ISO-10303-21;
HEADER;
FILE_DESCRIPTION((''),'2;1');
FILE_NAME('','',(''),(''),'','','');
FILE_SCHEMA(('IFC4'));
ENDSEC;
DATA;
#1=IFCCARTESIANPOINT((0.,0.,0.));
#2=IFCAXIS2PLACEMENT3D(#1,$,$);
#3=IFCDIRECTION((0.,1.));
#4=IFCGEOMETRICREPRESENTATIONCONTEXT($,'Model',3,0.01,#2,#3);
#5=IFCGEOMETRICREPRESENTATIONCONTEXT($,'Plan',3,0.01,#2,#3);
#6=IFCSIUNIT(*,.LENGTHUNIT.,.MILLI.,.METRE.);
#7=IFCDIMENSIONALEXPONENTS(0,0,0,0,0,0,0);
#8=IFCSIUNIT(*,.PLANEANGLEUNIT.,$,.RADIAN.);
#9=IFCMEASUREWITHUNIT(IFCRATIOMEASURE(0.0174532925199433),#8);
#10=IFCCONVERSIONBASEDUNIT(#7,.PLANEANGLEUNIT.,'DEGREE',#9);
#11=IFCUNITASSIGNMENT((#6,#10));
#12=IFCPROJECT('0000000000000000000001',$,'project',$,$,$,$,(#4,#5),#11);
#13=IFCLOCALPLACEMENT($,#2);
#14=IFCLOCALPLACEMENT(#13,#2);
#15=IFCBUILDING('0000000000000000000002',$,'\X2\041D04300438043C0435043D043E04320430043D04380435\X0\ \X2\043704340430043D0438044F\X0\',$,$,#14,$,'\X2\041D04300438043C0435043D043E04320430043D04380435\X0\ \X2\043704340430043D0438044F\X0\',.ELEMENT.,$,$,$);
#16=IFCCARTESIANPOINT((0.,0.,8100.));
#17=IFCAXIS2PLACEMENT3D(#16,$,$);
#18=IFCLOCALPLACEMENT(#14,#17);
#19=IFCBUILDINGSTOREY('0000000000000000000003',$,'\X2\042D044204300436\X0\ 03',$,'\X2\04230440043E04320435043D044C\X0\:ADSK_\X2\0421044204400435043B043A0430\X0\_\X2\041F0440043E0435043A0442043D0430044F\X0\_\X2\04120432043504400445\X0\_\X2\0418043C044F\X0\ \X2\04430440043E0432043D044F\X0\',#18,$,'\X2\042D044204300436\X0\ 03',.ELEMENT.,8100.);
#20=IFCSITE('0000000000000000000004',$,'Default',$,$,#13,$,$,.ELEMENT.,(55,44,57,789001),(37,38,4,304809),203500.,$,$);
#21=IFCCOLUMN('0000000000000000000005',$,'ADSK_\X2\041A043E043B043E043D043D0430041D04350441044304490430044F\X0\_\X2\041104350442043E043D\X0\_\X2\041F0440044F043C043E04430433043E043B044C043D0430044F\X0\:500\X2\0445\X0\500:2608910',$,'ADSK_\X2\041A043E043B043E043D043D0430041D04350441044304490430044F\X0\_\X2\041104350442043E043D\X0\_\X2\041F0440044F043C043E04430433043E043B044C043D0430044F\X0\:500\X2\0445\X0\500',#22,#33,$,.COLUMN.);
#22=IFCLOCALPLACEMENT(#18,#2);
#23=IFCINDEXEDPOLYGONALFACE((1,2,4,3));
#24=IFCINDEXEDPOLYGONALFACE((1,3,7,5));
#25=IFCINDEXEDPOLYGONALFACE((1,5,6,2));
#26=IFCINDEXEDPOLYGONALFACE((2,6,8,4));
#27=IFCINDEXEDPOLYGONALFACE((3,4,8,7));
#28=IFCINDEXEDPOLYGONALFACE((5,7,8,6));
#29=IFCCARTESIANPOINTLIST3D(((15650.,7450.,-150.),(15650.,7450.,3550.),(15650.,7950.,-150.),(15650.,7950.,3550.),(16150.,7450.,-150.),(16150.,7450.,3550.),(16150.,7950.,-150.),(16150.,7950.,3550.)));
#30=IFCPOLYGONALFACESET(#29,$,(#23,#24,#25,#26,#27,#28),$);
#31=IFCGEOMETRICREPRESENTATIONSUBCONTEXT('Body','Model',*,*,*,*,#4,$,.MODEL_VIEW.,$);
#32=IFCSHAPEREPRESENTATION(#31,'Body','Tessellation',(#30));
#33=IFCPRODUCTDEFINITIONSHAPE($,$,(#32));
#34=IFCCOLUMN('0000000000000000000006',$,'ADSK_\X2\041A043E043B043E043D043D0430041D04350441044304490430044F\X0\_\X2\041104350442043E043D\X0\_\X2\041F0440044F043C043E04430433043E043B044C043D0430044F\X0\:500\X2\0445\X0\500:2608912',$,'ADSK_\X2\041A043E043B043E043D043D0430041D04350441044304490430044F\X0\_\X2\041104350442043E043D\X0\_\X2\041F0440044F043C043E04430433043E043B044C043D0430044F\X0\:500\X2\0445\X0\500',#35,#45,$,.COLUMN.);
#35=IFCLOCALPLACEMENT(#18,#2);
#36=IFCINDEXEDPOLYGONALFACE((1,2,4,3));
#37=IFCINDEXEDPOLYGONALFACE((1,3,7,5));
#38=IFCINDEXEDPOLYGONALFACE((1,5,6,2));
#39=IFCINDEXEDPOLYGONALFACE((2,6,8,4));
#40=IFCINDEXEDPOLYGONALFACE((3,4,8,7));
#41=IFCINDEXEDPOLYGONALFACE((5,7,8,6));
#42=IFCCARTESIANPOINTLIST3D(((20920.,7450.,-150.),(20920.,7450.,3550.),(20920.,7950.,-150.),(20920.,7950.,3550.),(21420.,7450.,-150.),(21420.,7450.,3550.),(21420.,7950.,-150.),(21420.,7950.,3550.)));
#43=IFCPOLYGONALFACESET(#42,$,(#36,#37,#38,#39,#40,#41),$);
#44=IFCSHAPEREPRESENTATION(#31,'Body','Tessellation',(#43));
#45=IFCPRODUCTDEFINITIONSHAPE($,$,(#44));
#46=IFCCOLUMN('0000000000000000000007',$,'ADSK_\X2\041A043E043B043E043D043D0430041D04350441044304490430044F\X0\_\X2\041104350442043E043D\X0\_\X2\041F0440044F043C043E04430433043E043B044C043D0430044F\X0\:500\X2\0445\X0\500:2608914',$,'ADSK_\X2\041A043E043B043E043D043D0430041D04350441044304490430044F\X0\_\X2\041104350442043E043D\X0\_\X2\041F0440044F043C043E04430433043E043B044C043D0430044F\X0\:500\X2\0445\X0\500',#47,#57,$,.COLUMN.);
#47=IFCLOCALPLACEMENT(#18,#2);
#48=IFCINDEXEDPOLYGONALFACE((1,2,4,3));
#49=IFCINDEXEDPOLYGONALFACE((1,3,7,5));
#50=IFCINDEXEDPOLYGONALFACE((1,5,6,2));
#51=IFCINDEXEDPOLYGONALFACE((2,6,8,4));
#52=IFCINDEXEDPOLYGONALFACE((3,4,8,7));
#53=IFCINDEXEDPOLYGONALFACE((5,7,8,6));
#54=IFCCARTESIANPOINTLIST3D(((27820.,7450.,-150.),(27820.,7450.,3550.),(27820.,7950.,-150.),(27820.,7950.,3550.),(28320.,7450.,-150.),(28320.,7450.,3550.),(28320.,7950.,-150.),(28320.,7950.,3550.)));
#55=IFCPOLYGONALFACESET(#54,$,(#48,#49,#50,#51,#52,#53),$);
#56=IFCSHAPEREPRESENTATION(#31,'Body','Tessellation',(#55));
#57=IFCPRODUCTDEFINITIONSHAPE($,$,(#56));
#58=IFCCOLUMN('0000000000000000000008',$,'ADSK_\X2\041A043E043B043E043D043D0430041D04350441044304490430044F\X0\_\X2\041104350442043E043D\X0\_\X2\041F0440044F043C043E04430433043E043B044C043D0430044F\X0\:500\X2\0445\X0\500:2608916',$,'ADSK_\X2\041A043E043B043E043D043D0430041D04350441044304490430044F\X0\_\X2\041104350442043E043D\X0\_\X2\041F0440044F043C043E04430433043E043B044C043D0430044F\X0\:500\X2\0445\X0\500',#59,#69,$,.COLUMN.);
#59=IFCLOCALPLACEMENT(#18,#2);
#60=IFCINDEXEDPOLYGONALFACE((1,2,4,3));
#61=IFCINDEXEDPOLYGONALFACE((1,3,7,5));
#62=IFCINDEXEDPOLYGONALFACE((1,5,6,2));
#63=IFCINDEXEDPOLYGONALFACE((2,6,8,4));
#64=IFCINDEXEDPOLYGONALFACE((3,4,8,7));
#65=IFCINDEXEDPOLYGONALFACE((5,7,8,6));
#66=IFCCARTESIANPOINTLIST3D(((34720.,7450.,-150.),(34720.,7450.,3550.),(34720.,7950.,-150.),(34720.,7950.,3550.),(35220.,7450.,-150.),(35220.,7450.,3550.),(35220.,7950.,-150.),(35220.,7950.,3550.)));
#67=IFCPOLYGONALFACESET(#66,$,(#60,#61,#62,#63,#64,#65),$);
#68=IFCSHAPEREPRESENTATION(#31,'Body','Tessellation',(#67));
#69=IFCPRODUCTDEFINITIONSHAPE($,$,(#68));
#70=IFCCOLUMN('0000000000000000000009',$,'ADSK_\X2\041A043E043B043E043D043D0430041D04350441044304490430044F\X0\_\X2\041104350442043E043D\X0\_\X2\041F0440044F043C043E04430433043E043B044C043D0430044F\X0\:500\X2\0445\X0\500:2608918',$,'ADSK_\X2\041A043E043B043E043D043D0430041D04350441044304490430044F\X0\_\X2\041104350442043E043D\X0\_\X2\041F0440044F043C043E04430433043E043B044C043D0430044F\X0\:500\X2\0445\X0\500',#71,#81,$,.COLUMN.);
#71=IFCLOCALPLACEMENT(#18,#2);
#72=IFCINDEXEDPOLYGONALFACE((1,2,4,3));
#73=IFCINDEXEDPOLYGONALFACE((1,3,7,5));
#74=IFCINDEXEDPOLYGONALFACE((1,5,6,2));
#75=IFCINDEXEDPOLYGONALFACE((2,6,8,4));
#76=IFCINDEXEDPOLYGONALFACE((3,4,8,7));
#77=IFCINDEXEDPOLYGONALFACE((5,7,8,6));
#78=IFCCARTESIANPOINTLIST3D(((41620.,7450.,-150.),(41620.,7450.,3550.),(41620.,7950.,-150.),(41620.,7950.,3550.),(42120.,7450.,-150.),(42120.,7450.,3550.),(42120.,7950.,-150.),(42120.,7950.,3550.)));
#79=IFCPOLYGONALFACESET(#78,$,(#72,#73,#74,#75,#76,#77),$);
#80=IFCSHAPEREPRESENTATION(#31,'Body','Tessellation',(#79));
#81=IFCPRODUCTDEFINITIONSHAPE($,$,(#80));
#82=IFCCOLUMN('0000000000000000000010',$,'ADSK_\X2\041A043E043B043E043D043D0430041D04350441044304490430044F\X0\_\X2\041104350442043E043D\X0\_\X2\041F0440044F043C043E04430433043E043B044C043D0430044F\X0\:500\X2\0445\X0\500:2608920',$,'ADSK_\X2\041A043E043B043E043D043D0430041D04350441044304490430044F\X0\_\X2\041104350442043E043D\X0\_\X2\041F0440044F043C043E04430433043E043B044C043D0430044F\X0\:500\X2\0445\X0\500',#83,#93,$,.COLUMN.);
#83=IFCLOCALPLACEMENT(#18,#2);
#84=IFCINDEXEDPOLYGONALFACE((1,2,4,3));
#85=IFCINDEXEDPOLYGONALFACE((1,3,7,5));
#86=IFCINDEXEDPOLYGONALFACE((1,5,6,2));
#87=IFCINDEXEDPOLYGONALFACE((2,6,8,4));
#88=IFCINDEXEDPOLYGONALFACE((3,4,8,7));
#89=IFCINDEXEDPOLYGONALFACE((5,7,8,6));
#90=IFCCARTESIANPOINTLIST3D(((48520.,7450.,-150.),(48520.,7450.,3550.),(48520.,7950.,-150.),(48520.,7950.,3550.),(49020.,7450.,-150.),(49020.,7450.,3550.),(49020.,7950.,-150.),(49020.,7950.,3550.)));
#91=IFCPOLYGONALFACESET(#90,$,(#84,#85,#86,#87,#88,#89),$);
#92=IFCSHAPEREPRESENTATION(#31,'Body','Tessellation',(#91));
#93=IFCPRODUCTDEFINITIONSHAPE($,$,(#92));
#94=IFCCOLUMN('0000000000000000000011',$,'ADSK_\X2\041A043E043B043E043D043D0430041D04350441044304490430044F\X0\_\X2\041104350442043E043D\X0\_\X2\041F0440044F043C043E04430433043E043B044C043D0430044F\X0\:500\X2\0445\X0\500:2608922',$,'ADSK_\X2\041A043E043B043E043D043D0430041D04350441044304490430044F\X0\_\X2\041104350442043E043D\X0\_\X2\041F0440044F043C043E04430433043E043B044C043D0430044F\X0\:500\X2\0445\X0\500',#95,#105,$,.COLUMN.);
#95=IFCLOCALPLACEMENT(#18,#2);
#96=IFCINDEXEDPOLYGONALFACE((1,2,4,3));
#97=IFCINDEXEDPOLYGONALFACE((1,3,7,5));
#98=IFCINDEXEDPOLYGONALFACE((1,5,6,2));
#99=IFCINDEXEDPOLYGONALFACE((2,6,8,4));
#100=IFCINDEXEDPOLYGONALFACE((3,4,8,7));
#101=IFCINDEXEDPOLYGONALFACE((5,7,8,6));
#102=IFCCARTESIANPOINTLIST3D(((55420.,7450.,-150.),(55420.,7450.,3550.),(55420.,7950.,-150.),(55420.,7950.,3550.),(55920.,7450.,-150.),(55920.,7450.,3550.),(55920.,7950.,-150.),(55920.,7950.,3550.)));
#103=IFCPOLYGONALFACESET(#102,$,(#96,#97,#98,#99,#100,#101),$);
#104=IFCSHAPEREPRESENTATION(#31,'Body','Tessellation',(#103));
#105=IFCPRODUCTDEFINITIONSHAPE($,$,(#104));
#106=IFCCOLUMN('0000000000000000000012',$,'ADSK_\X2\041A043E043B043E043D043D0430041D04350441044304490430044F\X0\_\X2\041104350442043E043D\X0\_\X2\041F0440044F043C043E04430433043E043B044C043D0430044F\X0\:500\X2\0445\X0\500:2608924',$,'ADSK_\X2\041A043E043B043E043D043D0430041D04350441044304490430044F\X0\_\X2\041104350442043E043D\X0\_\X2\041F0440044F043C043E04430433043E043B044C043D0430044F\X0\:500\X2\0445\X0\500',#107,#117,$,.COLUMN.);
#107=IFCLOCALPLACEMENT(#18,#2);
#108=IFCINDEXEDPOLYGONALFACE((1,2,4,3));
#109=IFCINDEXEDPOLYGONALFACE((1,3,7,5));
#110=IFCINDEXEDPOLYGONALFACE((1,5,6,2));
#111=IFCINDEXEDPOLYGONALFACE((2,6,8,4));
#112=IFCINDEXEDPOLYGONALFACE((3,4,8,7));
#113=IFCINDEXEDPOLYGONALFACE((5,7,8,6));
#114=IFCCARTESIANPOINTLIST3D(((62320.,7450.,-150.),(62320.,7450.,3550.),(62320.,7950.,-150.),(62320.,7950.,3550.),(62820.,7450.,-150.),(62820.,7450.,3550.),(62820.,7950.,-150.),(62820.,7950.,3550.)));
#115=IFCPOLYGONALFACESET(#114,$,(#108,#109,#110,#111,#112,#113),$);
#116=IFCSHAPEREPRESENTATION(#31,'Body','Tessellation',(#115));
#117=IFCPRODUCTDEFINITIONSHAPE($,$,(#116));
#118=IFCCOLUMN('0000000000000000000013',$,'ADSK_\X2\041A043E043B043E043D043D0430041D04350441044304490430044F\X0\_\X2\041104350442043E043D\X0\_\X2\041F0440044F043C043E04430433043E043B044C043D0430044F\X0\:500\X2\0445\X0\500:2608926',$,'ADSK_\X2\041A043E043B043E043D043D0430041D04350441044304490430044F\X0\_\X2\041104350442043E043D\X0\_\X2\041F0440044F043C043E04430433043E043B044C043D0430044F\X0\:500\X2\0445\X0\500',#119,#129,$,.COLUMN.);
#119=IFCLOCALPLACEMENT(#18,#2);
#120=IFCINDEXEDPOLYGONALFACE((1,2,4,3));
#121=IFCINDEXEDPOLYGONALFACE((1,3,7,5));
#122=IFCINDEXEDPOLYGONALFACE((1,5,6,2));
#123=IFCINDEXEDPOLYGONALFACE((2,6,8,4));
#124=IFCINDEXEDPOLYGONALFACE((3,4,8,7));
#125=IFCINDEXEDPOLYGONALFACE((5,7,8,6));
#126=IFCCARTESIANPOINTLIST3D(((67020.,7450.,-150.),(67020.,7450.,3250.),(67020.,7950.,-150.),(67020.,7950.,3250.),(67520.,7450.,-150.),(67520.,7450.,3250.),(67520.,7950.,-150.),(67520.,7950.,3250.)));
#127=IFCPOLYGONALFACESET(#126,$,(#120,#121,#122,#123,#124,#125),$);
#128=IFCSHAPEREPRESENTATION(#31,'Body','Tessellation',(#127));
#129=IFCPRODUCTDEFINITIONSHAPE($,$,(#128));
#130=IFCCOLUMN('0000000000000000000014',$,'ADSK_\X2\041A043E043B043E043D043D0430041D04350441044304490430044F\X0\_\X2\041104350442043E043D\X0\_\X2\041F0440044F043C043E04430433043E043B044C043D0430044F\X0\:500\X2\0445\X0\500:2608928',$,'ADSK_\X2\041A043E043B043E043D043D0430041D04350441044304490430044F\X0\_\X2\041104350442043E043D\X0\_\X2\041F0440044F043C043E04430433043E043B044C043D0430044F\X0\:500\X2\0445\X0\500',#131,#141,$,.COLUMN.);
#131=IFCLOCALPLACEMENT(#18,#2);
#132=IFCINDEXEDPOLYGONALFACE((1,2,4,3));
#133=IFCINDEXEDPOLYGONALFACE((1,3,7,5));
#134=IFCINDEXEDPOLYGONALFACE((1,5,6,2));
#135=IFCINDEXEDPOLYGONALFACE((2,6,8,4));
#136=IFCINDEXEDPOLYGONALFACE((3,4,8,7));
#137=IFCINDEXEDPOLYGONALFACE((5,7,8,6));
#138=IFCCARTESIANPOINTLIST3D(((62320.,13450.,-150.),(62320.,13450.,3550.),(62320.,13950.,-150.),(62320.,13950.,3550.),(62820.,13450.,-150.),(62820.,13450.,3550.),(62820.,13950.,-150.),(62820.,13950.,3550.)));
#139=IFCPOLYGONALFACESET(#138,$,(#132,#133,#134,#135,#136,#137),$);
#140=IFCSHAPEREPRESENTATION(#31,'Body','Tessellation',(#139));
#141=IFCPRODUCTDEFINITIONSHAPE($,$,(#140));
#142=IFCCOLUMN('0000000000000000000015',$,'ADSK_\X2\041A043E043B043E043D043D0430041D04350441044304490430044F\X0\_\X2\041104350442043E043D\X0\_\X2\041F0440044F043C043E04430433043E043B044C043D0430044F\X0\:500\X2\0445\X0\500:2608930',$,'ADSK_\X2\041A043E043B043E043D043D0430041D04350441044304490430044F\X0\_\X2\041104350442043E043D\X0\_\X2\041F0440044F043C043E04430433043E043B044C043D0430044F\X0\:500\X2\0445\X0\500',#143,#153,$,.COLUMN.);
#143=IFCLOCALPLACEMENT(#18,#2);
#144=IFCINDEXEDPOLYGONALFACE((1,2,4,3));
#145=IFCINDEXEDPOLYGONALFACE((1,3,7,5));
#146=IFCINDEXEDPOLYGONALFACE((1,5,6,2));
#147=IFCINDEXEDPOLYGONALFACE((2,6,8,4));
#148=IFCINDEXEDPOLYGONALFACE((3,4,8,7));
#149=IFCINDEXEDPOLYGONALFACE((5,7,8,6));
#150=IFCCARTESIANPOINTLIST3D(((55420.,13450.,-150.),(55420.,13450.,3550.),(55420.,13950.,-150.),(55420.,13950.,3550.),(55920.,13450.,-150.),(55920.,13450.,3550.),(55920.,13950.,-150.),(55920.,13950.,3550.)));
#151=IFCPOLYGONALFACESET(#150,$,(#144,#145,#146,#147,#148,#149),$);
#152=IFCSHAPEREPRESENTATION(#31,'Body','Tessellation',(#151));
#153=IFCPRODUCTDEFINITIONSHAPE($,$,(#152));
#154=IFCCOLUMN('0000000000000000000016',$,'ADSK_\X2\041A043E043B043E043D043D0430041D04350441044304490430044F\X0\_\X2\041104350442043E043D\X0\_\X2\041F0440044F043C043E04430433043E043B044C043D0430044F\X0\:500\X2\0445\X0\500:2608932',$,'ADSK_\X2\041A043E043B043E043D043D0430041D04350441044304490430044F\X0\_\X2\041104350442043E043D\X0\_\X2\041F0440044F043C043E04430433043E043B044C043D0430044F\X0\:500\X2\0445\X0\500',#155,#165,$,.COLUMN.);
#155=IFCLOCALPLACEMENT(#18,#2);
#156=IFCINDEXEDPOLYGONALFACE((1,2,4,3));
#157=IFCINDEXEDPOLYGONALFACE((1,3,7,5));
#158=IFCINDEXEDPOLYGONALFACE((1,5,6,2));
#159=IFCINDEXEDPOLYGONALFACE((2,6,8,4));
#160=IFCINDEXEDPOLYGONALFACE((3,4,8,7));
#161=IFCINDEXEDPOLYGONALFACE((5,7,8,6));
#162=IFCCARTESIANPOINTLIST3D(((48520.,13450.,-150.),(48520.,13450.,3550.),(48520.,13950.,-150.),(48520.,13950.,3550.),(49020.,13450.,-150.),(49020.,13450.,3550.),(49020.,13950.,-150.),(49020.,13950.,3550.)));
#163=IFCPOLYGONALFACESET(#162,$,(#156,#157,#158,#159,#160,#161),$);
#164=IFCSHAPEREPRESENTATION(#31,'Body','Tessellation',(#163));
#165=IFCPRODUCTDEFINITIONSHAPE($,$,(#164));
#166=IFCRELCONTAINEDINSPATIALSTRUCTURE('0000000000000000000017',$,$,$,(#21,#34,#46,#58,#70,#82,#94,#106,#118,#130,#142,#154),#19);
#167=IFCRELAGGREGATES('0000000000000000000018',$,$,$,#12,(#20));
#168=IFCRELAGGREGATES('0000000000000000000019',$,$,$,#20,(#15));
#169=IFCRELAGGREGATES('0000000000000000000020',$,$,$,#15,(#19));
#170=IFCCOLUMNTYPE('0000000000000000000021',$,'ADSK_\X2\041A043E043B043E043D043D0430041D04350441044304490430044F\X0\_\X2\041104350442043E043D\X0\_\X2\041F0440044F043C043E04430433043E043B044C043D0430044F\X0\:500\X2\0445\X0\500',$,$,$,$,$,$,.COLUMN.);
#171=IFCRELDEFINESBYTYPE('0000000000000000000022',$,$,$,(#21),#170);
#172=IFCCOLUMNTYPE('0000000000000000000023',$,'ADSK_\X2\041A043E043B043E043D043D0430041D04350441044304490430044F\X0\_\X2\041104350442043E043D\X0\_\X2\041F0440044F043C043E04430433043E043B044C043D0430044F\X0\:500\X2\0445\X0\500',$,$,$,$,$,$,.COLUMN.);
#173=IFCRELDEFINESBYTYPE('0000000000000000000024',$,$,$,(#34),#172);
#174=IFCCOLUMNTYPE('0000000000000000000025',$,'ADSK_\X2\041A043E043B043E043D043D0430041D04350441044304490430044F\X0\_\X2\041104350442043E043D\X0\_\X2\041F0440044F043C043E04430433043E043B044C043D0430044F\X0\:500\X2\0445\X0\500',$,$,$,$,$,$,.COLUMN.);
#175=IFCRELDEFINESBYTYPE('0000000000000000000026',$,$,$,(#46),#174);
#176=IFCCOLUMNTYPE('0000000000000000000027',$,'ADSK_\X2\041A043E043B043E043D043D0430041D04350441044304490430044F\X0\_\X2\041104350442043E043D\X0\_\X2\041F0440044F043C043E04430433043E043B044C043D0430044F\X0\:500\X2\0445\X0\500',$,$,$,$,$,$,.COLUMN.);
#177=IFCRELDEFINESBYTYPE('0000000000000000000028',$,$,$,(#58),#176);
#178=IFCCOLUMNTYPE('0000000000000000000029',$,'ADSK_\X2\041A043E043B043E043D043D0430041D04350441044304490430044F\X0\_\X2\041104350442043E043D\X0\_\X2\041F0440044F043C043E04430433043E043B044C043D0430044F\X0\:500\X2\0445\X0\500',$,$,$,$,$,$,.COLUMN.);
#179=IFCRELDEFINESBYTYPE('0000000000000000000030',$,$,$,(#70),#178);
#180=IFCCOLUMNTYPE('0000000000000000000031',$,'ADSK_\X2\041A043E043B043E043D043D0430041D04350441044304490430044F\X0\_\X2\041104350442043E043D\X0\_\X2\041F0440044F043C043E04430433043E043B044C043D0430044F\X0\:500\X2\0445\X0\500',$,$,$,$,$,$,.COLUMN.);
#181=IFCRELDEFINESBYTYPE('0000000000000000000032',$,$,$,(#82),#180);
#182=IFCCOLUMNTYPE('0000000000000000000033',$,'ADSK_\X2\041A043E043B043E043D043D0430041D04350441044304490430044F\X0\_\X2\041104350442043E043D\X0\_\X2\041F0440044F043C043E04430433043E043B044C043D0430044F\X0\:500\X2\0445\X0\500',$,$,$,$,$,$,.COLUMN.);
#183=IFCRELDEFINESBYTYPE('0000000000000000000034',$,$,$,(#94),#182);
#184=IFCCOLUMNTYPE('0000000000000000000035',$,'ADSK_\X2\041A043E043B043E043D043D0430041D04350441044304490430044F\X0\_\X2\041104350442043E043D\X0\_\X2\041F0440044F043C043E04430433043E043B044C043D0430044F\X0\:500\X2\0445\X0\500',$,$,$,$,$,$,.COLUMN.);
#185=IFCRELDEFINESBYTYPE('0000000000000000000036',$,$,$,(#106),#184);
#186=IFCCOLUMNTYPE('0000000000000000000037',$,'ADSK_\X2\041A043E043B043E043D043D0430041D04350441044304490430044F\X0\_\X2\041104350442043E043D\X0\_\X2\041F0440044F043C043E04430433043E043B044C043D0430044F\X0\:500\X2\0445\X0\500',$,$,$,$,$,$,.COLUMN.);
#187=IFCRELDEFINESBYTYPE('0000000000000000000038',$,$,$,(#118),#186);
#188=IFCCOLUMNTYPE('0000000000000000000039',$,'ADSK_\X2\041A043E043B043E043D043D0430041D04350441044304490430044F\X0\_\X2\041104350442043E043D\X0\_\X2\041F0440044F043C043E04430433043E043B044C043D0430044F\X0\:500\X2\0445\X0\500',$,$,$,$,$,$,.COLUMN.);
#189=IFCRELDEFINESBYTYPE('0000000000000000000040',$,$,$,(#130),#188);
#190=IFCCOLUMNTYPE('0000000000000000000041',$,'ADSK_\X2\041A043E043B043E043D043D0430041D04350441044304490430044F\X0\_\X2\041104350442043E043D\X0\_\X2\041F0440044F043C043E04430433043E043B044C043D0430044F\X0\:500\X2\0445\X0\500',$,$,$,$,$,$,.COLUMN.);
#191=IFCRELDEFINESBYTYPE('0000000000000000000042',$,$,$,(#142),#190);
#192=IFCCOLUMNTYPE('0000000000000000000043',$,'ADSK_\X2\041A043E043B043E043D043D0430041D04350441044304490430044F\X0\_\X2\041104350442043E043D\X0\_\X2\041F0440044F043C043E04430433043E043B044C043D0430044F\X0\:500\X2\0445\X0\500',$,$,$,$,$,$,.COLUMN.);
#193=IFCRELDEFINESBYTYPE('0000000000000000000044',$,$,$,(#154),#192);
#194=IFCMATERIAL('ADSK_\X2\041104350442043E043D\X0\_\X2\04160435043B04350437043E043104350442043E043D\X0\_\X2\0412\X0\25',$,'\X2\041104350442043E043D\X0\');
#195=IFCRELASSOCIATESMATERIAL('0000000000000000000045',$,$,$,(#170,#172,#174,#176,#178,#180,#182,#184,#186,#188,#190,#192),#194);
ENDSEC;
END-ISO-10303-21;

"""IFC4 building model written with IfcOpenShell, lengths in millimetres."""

from ifc_helpers import new_model, entity, si_unit, converted_unit, direction, frame, origin, place, context, subcontext, project, spatial, indexed_curve, outline, extrude, source, transform, mapped, material, type_object, type_shapes, element, save


model = new_model("IFC4")

# Units and contexts
model_context = context("Model", 3, precision=0.01, world=origin(), true_north=direction((0.0, 1.0)))
plan_context = context("Plan", 3, precision=0.01, world=origin(), true_north=direction((0.0, 1.0)))
body_context = subcontext(model_context, "Body", "Model", "MODEL_VIEW")
ifc_project = project(units=[si_unit("LENGTHUNIT", "METRE", prefix="MILLI"), converted_unit("PLANEANGLEUNIT", "DEGREE", entity("IfcRatioMeasure", 0.0174532925199433), si_unit("PLANEANGLEUNIT", "RADIAN"), dimensions=[0, 0, 0, 0, 0, 0, 0])], contexts=[model_context, plan_context])

# Site, building, storey
site_placement = place(None, origin())
site = spatial("IfcSite", under=ifc_project, at=site_placement, Name="Default", CompositionType="ELEMENT", RefLatitude=(55, 44, 57, 789001), RefLongitude=(37, 38, 4, 304809), RefElevation=203500.0)
building_placement = place(site_placement, origin())
building = spatial("IfcBuilding", under=site, at=building_placement, Name="Наименование здания", LongName="Наименование здания", CompositionType="ELEMENT")
storey_placement = place(building_placement, frame((0.0, 0.0, 8100.0)))
storey = spatial("IfcBuildingStorey", under=building, at=storey_placement, Name="Этаж 03", ObjectType="Уровень:ADSK_Стрелка_Проектная_Вверх_Имя уровня", LongName="Этаж 03", CompositionType="ELEMENT", Elevation=8100.0)

# Columns
ifc_material_1 = material(Name="ADSK_Бетон_Железобетон_В25", Category="Бетон")
column_type_1 = type_object("IfcColumnType", Name="ADSK_КолоннаНесущая_Бетон_Прямоугольная:500х500", PredefinedType="COLUMN", material=ifc_material_1)
shared_shape_1 = source(origin(), body_context, "Body", "SweptSolid", [
    extrude(outline(indexed_curve([(-250.0, -250.0), (250.0, -250.0), (250.0, 250.0), (-250.0, 250.0), (-250.0, -250.0)], self_intersect=False)), frame((15900.0, 7700.0, 7950.0), z_axis=(0.0, 0.0, 1.0), x_axis=(0.0, -1.0, 0.0)), (0.0, 0.0, 1.0), 3700.0),
])
type_shapes(column_type_1, [shared_shape_1])
column_1_placement = place(storey_placement, frame((0.0, 0.0, -8100.0)))
element("IfcColumn", 1, at=column_1_placement, inside=storey, type_object=column_type_1, Name="ADSK_КолоннаНесущая_Бетон_Прямоугольная:500х500:2608910", ObjectType="ADSK_КолоннаНесущая_Бетон_Прямоугольная:500х500", PredefinedType="COLUMN", context=body_context, shape_type="MappedRepresentation", body=[
    mapped(shared_shape_1, transform((0.0, 0.0, 0.0), scale=1.0)),
])
column_type_2 = type_object("IfcColumnType", Name="ADSK_КолоннаНесущая_Бетон_Прямоугольная:500х500", PredefinedType="COLUMN", material=ifc_material_1)
shared_shape_2 = source(origin(), body_context, "Body", "SweptSolid", [
    extrude(outline(indexed_curve([(-250.0, -250.0), (250.0, -250.0), (250.0, 250.0), (-250.0, 250.0), (-250.0, -250.0)], self_intersect=False)), frame((21170.0, 7700.0, 7950.0), z_axis=(0.0, 0.0, 1.0), x_axis=(0.0, -1.0, 0.0)), (0.0, 0.0, 1.0), 3700.0),
])
type_shapes(column_type_2, [shared_shape_2])
column_2_placement = place(storey_placement, frame((0.0, 0.0, -8100.0)))
element("IfcColumn", 2, at=column_2_placement, inside=storey, type_object=column_type_2, Name="ADSK_КолоннаНесущая_Бетон_Прямоугольная:500х500:2608912", ObjectType="ADSK_КолоннаНесущая_Бетон_Прямоугольная:500х500", PredefinedType="COLUMN", context=body_context, shape_type="MappedRepresentation", body=[
    mapped(shared_shape_2, transform((0.0, 0.0, 0.0), scale=1.0)),
])
column_type_3 = type_object("IfcColumnType", Name="ADSK_КолоннаНесущая_Бетон_Прямоугольная:500х500", PredefinedType="COLUMN", material=ifc_material_1)
shared_shape_3 = source(origin(), body_context, "Body", "SweptSolid", [
    extrude(outline(indexed_curve([(-250.0, -250.0), (250.0, -250.0), (250.0, 250.0), (-250.0, 250.0), (-250.0, -250.0)], self_intersect=False)), frame((28070.0, 7700.0, 7950.0), z_axis=(0.0, 0.0, 1.0), x_axis=(0.0, -1.0, 0.0)), (0.0, 0.0, 1.0), 3700.0),
])
type_shapes(column_type_3, [shared_shape_3])
column_3_placement = place(storey_placement, frame((0.0, 0.0, -8100.0)))
element("IfcColumn", 3, at=column_3_placement, inside=storey, type_object=column_type_3, Name="ADSK_КолоннаНесущая_Бетон_Прямоугольная:500х500:2608914", ObjectType="ADSK_КолоннаНесущая_Бетон_Прямоугольная:500х500", PredefinedType="COLUMN", context=body_context, shape_type="MappedRepresentation", body=[
    mapped(shared_shape_3, transform((0.0, 0.0, 0.0), scale=1.0)),
])
column_type_4 = type_object("IfcColumnType", Name="ADSK_КолоннаНесущая_Бетон_Прямоугольная:500х500", PredefinedType="COLUMN", material=ifc_material_1)
shared_shape_4 = source(origin(), body_context, "Body", "SweptSolid", [
    extrude(outline(indexed_curve([(-250.0, -250.0), (250.0, -250.0), (250.0, 250.0), (-250.0, 250.0), (-250.0, -250.0)], self_intersect=False)), frame((34970.0, 7700.0, 7950.0), z_axis=(0.0, 0.0, 1.0), x_axis=(0.0, -1.0, 0.0)), (0.0, 0.0, 1.0), 3700.0),
])
type_shapes(column_type_4, [shared_shape_4])
column_4_placement = place(storey_placement, frame((0.0, 0.0, -8100.0)))
element("IfcColumn", 4, at=column_4_placement, inside=storey, type_object=column_type_4, Name="ADSK_КолоннаНесущая_Бетон_Прямоугольная:500х500:2608916", ObjectType="ADSK_КолоннаНесущая_Бетон_Прямоугольная:500х500", PredefinedType="COLUMN", context=body_context, shape_type="MappedRepresentation", body=[
    mapped(shared_shape_4, transform((0.0, 0.0, 0.0), scale=1.0)),
])
column_type_5 = type_object("IfcColumnType", Name="ADSK_КолоннаНесущая_Бетон_Прямоугольная:500х500", PredefinedType="COLUMN", material=ifc_material_1)
shared_shape_5 = source(origin(), body_context, "Body", "SweptSolid", [
    extrude(outline(indexed_curve([(-250.0, -250.0), (250.0, -250.0), (250.0, 250.0), (-250.0, 250.0), (-250.0, -250.0)], self_intersect=False)), frame((41870.0, 7700.0, 7950.0), z_axis=(0.0, 0.0, 1.0), x_axis=(0.0, -1.0, 0.0)), (0.0, 0.0, 1.0), 3700.0),
])
type_shapes(column_type_5, [shared_shape_5])
column_5_placement = place(storey_placement, frame((0.0, 0.0, -8100.0)))
element("IfcColumn", 5, at=column_5_placement, inside=storey, type_object=column_type_5, Name="ADSK_КолоннаНесущая_Бетон_Прямоугольная:500х500:2608918", ObjectType="ADSK_КолоннаНесущая_Бетон_Прямоугольная:500х500", PredefinedType="COLUMN", context=body_context, shape_type="MappedRepresentation", body=[
    mapped(shared_shape_5, transform((0.0, 0.0, 0.0), scale=1.0)),
])
column_type_6 = type_object("IfcColumnType", Name="ADSK_КолоннаНесущая_Бетон_Прямоугольная:500х500", PredefinedType="COLUMN", material=ifc_material_1)
shared_shape_6 = source(origin(), body_context, "Body", "SweptSolid", [
    extrude(outline(indexed_curve([(-250.0, -250.0), (250.0, -250.0), (250.0, 250.0), (-250.0, 250.0), (-250.0, -250.0)], self_intersect=False)), frame((48770.0, 7700.0, 7950.0), z_axis=(0.0, 0.0, 1.0), x_axis=(0.0, -1.0, 0.0)), (0.0, 0.0, 1.0), 3700.0),
])
type_shapes(column_type_6, [shared_shape_6])
column_6_placement = place(storey_placement, frame((0.0, 0.0, -8100.0)))
element("IfcColumn", 6, at=column_6_placement, inside=storey, type_object=column_type_6, Name="ADSK_КолоннаНесущая_Бетон_Прямоугольная:500х500:2608920", ObjectType="ADSK_КолоннаНесущая_Бетон_Прямоугольная:500х500", PredefinedType="COLUMN", context=body_context, shape_type="MappedRepresentation", body=[
    mapped(shared_shape_6, transform((0.0, 0.0, 0.0), scale=1.0)),
])
column_type_7 = type_object("IfcColumnType", Name="ADSK_КолоннаНесущая_Бетон_Прямоугольная:500х500", PredefinedType="COLUMN", material=ifc_material_1)
shared_shape_7 = source(origin(), body_context, "Body", "SweptSolid", [
    extrude(outline(indexed_curve([(-250.0, -250.0), (250.0, -250.0), (250.0, 250.0), (-250.0, 250.0), (-250.0, -250.0)], self_intersect=False)), frame((55670.0, 7700.0, 7950.0), z_axis=(0.0, 0.0, 1.0), x_axis=(0.0, -1.0, 0.0)), (0.0, 0.0, 1.0), 3700.0),
])
type_shapes(column_type_7, [shared_shape_7])
column_7_placement = place(storey_placement, frame((0.0, 0.0, -8100.0)))
element("IfcColumn", 7, at=column_7_placement, inside=storey, type_object=column_type_7, Name="ADSK_КолоннаНесущая_Бетон_Прямоугольная:500х500:2608922", ObjectType="ADSK_КолоннаНесущая_Бетон_Прямоугольная:500х500", PredefinedType="COLUMN", context=body_context, shape_type="MappedRepresentation", body=[
    mapped(shared_shape_7, transform((0.0, 0.0, 0.0), scale=1.0)),
])
column_type_8 = type_object("IfcColumnType", Name="ADSK_КолоннаНесущая_Бетон_Прямоугольная:500х500", PredefinedType="COLUMN", material=ifc_material_1)
shared_shape_8 = source(origin(), body_context, "Body", "SweptSolid", [
    extrude(outline(indexed_curve([(-250.0, -250.0), (250.0, -250.0), (250.0, 250.0), (-250.0, 250.0), (-250.0, -250.0)], self_intersect=False)), frame((62570.0, 7700.0, 7950.0), z_axis=(0.0, 0.0, 1.0), x_axis=(0.0, -1.0, 0.0)), (0.0, 0.0, 1.0), 3700.0),
])
type_shapes(column_type_8, [shared_shape_8])
column_8_placement = place(storey_placement, frame((0.0, 0.0, -8100.0)))
element("IfcColumn", 8, at=column_8_placement, inside=storey, type_object=column_type_8, Name="ADSK_КолоннаНесущая_Бетон_Прямоугольная:500х500:2608924", ObjectType="ADSK_КолоннаНесущая_Бетон_Прямоугольная:500х500", PredefinedType="COLUMN", context=body_context, shape_type="MappedRepresentation", body=[
    mapped(shared_shape_8, transform((0.0, 0.0, 0.0), scale=1.0)),
])
column_type_9 = type_object("IfcColumnType", Name="ADSK_КолоннаНесущая_Бетон_Прямоугольная:500х500", PredefinedType="COLUMN", material=ifc_material_1)
shared_shape_9 = source(origin(), body_context, "Body", "SweptSolid", [
    extrude(outline(indexed_curve([(-250.0, -250.0), (250.0, -250.0), (250.0, 250.0), (-250.0, 250.0), (-250.0, -250.0)], self_intersect=False)), frame((67270.0, 7700.0, 7950.0), z_axis=(0.0, 0.0, 1.0), x_axis=(0.0, -1.0, 0.0)), (0.0, 0.0, 1.0), 3400.0),
])
type_shapes(column_type_9, [shared_shape_9])
column_9_placement = place(storey_placement, frame((0.0, 0.0, -8100.0)))
element("IfcColumn", 9, at=column_9_placement, inside=storey, type_object=column_type_9, Name="ADSK_КолоннаНесущая_Бетон_Прямоугольная:500х500:2608926", ObjectType="ADSK_КолоннаНесущая_Бетон_Прямоугольная:500х500", PredefinedType="COLUMN", context=body_context, shape_type="MappedRepresentation", body=[
    mapped(shared_shape_9, transform((0.0, 0.0, 0.0), scale=1.0)),
])
column_type_10 = type_object("IfcColumnType", Name="ADSK_КолоннаНесущая_Бетон_Прямоугольная:500х500", PredefinedType="COLUMN", material=ifc_material_1)
shared_shape_10 = source(origin(), body_context, "Body", "SweptSolid", [
    extrude(outline(indexed_curve([(-250.0, -250.0), (250.0, -250.0), (250.0, 250.0), (-250.0, 250.0), (-250.0, -250.0)], self_intersect=False)), frame((62570.0, 13700.0, 7950.0), z_axis=(0.0, 0.0, 1.0), x_axis=(0.0, -1.0, 0.0)), (0.0, 0.0, 1.0), 3700.0),
])
type_shapes(column_type_10, [shared_shape_10])
column_10_placement = place(storey_placement, frame((0.0, 0.0, -8100.0)))
element("IfcColumn", 10, at=column_10_placement, inside=storey, type_object=column_type_10, Name="ADSK_КолоннаНесущая_Бетон_Прямоугольная:500х500:2608928", ObjectType="ADSK_КолоннаНесущая_Бетон_Прямоугольная:500х500", PredefinedType="COLUMN", context=body_context, shape_type="MappedRepresentation", body=[
    mapped(shared_shape_10, transform((0.0, 0.0, 0.0), scale=1.0)),
])
column_type_11 = type_object("IfcColumnType", Name="ADSK_КолоннаНесущая_Бетон_Прямоугольная:500х500", PredefinedType="COLUMN", material=ifc_material_1)
shared_shape_11 = source(origin(), body_context, "Body", "SweptSolid", [
    extrude(outline(indexed_curve([(-250.0, -250.0), (250.0, -250.0), (250.0, 250.0), (-250.0, 250.0), (-250.0, -250.0)], self_intersect=False)), frame((55670.0, 13700.0, 7950.0), z_axis=(0.0, 0.0, 1.0), x_axis=(0.0, -1.0, 0.0)), (0.0, 0.0, 1.0), 3700.0),
])
type_shapes(column_type_11, [shared_shape_11])
column_11_placement = place(storey_placement, frame((0.0, 0.0, -8100.0)))
element("IfcColumn", 11, at=column_11_placement, inside=storey, type_object=column_type_11, Name="ADSK_КолоннаНесущая_Бетон_Прямоугольная:500х500:2608930", ObjectType="ADSK_КолоннаНесущая_Бетон_Прямоугольная:500х500", PredefinedType="COLUMN", context=body_context, shape_type="MappedRepresentation", body=[
    mapped(shared_shape_11, transform((0.0, 0.0, 0.0), scale=1.0)),
])
column_type_12 = type_object("IfcColumnType", Name="ADSK_КолоннаНесущая_Бетон_Прямоугольная:500х500", PredefinedType="COLUMN", material=ifc_material_1)
shared_shape_12 = source(origin(), body_context, "Body", "SweptSolid", [
    extrude(outline(indexed_curve([(-250.0, -250.0), (250.0, -250.0), (250.0, 250.0), (-250.0, 250.0), (-250.0, -250.0)], self_intersect=False)), frame((48770.0, 13700.0, 7950.0), z_axis=(0.0, 0.0, 1.0), x_axis=(0.0, -1.0, 0.0)), (0.0, 0.0, 1.0), 3700.0),
])
type_shapes(column_type_12, [shared_shape_12])
column_12_placement = place(storey_placement, frame((0.0, 0.0, -8100.0)))
element("IfcColumn", 12, at=column_12_placement, inside=storey, type_object=column_type_12, Name="ADSK_КолоннаНесущая_Бетон_Прямоугольная:500х500:2608932", ObjectType="ADSK_КолоннаНесущая_Бетон_Прямоугольная:500х500", PredefinedType="COLUMN", context=body_context, shape_type="MappedRepresentation", body=[
    mapped(shared_shape_12, transform((0.0, 0.0, 0.0), scale=1.0)),
])

save(model, "model.ifc")
